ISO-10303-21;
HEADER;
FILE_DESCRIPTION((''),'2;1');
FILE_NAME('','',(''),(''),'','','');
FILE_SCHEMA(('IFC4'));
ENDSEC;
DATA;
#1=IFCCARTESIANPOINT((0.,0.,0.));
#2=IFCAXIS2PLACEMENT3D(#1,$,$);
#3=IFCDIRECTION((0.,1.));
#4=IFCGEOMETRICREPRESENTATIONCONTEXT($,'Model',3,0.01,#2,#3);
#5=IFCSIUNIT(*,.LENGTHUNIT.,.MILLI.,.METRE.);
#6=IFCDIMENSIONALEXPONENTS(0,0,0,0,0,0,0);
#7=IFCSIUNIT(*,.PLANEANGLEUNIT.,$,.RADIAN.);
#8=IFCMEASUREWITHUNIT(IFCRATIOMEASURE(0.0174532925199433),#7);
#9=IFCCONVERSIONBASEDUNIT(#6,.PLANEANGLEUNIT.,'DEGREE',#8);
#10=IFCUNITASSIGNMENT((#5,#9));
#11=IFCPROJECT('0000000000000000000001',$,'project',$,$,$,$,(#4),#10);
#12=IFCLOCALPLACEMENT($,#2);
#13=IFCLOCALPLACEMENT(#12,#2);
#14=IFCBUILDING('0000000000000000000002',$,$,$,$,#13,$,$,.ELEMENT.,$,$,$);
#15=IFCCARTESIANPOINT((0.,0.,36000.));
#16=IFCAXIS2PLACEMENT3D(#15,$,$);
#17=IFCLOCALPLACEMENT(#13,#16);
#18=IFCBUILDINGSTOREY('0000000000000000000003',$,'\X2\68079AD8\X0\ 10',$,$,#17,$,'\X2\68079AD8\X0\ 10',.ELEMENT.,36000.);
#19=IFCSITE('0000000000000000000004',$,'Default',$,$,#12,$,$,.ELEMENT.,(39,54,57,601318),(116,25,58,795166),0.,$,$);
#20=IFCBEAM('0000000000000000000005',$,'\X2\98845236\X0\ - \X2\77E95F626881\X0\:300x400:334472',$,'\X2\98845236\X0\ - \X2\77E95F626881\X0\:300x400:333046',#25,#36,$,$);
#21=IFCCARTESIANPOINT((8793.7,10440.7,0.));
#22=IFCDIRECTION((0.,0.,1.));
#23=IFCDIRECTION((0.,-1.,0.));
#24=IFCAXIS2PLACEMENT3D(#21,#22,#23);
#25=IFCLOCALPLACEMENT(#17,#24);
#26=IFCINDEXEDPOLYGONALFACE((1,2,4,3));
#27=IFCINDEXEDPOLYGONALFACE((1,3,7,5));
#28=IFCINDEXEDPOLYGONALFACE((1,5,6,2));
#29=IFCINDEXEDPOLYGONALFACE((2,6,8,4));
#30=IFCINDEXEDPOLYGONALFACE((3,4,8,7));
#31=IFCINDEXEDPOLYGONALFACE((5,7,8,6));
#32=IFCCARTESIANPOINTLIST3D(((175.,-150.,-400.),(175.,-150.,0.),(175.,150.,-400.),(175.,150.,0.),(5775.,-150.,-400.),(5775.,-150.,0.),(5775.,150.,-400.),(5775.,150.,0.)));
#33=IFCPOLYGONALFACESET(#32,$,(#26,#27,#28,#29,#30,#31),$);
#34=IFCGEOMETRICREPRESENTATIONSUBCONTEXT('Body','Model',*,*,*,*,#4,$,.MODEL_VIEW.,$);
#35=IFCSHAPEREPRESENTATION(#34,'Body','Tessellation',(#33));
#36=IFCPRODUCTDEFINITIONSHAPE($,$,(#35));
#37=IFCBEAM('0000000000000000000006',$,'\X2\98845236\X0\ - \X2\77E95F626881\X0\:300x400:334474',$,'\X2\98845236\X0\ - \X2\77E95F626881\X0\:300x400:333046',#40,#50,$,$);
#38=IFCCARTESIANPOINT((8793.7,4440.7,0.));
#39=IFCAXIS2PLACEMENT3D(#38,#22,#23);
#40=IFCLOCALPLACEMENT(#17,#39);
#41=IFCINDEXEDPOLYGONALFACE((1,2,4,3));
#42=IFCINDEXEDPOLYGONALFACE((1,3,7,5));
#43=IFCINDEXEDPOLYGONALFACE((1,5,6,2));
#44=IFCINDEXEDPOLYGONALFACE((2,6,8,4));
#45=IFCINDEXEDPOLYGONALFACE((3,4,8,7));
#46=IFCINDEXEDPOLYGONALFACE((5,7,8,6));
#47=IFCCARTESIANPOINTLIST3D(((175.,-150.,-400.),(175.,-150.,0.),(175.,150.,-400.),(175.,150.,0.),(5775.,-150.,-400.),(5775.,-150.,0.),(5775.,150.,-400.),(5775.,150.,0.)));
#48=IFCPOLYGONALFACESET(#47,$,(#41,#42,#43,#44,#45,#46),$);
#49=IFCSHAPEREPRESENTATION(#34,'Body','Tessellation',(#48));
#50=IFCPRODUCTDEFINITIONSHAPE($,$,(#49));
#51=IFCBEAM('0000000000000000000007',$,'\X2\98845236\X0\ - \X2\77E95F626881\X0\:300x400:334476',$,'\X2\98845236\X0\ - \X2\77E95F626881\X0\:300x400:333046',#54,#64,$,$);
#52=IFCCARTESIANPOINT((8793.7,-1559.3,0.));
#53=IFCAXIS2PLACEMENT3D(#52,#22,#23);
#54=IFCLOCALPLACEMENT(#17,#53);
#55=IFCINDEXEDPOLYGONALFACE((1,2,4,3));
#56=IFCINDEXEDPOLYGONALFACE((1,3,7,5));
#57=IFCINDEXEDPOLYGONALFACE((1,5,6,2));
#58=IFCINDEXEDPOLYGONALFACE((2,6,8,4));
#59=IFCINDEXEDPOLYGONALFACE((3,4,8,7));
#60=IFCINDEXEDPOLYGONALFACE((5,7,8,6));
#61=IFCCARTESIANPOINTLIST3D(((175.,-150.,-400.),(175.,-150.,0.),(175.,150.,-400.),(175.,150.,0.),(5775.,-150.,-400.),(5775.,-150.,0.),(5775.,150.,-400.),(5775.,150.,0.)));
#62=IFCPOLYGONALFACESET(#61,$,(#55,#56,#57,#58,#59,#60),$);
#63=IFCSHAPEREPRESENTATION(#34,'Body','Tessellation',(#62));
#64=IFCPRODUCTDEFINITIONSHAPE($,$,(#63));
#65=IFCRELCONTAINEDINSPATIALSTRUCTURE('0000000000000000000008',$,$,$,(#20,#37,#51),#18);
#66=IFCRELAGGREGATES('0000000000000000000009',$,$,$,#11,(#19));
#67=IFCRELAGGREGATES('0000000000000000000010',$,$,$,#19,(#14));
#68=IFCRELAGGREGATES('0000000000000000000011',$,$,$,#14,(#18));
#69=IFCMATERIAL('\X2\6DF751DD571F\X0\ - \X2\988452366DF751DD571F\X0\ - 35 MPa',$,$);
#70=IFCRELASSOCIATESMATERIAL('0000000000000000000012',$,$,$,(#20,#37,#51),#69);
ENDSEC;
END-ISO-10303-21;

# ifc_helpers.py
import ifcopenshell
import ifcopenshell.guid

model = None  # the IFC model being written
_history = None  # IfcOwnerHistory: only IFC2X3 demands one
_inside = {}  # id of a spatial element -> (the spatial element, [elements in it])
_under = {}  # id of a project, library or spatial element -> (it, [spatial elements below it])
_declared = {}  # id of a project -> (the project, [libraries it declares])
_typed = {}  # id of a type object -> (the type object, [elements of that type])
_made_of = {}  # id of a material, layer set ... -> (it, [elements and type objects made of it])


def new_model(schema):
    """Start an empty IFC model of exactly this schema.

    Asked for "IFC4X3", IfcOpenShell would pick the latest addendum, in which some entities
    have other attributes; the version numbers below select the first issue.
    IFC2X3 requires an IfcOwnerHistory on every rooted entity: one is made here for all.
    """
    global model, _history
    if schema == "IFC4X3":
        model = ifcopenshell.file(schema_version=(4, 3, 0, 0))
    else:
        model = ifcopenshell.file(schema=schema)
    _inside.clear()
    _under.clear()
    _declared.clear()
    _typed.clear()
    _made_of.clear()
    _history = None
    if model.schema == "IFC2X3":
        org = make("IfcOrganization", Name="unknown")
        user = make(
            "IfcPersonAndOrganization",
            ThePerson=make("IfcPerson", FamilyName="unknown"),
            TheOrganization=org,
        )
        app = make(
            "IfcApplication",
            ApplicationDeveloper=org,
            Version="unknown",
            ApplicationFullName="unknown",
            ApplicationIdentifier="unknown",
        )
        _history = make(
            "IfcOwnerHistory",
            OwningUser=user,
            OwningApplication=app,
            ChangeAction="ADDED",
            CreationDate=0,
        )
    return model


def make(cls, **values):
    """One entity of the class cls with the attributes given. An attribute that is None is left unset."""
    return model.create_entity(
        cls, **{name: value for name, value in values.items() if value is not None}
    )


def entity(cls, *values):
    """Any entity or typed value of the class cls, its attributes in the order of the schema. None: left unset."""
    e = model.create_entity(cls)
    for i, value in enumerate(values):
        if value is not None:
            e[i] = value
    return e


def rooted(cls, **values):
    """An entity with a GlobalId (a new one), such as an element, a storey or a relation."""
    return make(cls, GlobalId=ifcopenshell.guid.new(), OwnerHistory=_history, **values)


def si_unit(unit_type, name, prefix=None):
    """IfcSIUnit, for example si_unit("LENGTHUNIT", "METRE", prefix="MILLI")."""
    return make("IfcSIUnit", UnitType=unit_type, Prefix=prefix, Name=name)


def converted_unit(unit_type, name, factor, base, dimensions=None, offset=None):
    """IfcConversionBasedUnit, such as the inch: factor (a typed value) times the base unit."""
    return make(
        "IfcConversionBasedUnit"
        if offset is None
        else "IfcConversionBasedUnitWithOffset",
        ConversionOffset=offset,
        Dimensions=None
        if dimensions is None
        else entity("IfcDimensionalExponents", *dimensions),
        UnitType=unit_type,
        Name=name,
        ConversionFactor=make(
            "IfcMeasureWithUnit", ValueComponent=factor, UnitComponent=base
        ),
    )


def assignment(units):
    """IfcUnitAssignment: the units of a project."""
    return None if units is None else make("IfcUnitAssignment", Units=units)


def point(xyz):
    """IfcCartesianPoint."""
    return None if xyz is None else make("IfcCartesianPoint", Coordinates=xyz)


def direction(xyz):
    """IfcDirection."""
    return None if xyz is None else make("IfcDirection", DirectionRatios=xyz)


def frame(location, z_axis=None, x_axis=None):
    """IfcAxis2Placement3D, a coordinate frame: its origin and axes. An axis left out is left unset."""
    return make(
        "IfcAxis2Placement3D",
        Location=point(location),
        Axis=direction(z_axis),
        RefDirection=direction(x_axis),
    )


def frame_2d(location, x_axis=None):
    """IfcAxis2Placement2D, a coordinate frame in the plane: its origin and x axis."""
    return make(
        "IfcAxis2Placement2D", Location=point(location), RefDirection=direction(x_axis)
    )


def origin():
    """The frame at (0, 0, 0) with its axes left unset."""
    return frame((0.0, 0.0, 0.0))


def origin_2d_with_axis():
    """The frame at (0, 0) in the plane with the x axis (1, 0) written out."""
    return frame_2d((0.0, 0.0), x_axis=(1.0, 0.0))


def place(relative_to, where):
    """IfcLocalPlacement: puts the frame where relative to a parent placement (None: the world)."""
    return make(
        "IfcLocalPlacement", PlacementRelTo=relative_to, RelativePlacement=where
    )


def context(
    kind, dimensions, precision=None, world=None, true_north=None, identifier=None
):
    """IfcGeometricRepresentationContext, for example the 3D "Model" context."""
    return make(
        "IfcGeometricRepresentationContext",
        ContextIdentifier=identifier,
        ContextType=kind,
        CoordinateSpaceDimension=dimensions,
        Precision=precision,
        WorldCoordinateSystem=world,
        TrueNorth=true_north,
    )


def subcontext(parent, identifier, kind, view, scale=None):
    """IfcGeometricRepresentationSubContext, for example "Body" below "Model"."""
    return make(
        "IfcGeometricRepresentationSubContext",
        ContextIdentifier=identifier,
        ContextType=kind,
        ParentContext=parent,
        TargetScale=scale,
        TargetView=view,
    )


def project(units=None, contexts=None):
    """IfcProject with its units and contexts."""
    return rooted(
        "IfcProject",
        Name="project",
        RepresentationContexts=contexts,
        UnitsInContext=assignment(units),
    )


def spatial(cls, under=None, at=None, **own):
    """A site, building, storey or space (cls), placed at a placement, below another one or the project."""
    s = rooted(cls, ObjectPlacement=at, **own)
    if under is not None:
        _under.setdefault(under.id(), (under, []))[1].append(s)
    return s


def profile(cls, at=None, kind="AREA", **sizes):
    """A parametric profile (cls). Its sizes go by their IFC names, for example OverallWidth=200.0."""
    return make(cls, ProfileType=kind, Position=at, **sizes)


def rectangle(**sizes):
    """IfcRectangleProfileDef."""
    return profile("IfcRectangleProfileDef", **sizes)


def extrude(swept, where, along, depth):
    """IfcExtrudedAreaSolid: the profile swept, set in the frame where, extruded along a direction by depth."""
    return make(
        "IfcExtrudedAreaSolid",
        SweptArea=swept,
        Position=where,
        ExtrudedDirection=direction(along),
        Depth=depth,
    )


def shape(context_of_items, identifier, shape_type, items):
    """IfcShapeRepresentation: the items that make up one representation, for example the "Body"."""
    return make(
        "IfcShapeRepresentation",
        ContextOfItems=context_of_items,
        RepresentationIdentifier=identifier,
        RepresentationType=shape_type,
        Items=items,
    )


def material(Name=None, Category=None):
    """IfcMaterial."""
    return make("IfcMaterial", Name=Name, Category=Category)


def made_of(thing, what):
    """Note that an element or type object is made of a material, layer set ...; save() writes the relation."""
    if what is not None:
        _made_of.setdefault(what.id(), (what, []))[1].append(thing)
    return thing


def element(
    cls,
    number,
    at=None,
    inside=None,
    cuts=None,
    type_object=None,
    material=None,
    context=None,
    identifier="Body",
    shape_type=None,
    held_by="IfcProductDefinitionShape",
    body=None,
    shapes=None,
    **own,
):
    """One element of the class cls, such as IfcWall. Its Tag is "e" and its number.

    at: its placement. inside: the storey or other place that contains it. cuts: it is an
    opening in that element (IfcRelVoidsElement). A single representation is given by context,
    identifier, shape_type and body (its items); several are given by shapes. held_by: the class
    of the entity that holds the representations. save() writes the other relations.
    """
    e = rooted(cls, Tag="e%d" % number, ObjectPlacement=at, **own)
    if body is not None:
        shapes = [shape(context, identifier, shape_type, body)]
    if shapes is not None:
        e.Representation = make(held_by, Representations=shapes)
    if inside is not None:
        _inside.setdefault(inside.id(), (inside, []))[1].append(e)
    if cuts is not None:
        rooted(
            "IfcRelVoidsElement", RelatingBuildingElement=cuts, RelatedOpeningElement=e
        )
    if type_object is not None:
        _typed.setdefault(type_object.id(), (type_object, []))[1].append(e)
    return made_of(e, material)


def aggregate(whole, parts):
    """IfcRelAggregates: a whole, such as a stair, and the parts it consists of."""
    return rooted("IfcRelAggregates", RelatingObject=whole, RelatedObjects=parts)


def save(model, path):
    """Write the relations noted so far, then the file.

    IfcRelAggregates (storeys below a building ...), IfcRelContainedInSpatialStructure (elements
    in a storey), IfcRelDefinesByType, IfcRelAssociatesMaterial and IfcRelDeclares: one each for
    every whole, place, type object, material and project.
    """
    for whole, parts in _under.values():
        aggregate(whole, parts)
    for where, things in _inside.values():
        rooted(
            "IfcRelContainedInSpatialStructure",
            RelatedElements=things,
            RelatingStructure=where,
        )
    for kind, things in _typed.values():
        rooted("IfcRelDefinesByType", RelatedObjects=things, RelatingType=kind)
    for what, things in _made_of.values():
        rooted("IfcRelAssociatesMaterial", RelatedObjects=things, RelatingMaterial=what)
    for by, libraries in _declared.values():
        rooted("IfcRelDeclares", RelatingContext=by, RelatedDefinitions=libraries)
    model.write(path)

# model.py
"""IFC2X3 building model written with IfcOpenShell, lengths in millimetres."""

from ifc_helpers import new_model, entity, si_unit, converted_unit, direction, frame, origin, origin_2d_with_axis, place, context, subcontext, project, spatial, rectangle, extrude, material, element, save


model = new_model("IFC2X3")

# Units and contexts
model_context = context("Model", 3, precision=0.01, world=origin(), true_north=direction((0.0, 1.0)))
body_context = subcontext(model_context, "Body", "Model", "MODEL_VIEW")
ifc_project = project(units=[si_unit("LENGTHUNIT", "METRE", prefix="MILLI"), converted_unit("PLANEANGLEUNIT", "DEGREE", entity("IfcRatioMeasure", 0.0174532925199433), si_unit("PLANEANGLEUNIT", "RADIAN"), dimensions=[0, 0, 0, 0, 0, 0, 0])], contexts=[model_context])

# Site, building, storey
site_placement = place(None, origin())
site = spatial("IfcSite", under=ifc_project, at=site_placement, Name="Default", CompositionType="ELEMENT", RefLatitude=(39, 54, 57, 601318), RefLongitude=(116, 25, 58, 795166), RefElevation=0.0)
building_placement = place(site_placement, origin())
building = spatial("IfcBuilding", under=site, at=building_placement, CompositionType="ELEMENT")
storey_placement = place(building_placement, frame((0.0, 0.0, 36000.0)))
storey = spatial("IfcBuildingStorey", under=building, at=storey_placement, Name="标高 10", LongName="标高 10", CompositionType="ELEMENT", Elevation=36000.0)

# Beams
ifc_material_1 = material(Name="混凝土 - 预制混凝土 - 35 MPa")
for number, where, z_axis, x_axis, name in (
    (1, (8793.7, 10440.7, 0.0), (0.0, 0.0, 1.0), (0.0, -1.0, 0.0), "预制 - 矩形梁:300x400:334472"),
    (2, (8793.7, 4440.7, 0.0), (0.0, 0.0, 1.0), (0.0, -1.0, 0.0), "预制 - 矩形梁:300x400:334474"),
    (3, (8793.7, -1559.3, 0.0), (0.0, 0.0, 1.0), (0.0, -1.0, 0.0), "预制 - 矩形梁:300x400:334476"),
):
    element("IfcBeam", number, at=place(storey_placement, frame(where, z_axis=z_axis, x_axis=x_axis)), inside=storey, material=ifc_material_1, Name=name, ObjectType="预制 - 矩形梁:300x400:333046", context=body_context, shape_type="SweptSolid", body=[
        extrude(rectangle(XDim=400.0, YDim=300.0, at=origin_2d_with_axis()), frame((175.0, 0.0, -200.0), z_axis=(1.0, 0.0, 0.0), x_axis=(0.0, 0.0, -1.0)), (0.0, 0.0, 1.0), 5600.0),
    ])

save(model, "model.ifc")
